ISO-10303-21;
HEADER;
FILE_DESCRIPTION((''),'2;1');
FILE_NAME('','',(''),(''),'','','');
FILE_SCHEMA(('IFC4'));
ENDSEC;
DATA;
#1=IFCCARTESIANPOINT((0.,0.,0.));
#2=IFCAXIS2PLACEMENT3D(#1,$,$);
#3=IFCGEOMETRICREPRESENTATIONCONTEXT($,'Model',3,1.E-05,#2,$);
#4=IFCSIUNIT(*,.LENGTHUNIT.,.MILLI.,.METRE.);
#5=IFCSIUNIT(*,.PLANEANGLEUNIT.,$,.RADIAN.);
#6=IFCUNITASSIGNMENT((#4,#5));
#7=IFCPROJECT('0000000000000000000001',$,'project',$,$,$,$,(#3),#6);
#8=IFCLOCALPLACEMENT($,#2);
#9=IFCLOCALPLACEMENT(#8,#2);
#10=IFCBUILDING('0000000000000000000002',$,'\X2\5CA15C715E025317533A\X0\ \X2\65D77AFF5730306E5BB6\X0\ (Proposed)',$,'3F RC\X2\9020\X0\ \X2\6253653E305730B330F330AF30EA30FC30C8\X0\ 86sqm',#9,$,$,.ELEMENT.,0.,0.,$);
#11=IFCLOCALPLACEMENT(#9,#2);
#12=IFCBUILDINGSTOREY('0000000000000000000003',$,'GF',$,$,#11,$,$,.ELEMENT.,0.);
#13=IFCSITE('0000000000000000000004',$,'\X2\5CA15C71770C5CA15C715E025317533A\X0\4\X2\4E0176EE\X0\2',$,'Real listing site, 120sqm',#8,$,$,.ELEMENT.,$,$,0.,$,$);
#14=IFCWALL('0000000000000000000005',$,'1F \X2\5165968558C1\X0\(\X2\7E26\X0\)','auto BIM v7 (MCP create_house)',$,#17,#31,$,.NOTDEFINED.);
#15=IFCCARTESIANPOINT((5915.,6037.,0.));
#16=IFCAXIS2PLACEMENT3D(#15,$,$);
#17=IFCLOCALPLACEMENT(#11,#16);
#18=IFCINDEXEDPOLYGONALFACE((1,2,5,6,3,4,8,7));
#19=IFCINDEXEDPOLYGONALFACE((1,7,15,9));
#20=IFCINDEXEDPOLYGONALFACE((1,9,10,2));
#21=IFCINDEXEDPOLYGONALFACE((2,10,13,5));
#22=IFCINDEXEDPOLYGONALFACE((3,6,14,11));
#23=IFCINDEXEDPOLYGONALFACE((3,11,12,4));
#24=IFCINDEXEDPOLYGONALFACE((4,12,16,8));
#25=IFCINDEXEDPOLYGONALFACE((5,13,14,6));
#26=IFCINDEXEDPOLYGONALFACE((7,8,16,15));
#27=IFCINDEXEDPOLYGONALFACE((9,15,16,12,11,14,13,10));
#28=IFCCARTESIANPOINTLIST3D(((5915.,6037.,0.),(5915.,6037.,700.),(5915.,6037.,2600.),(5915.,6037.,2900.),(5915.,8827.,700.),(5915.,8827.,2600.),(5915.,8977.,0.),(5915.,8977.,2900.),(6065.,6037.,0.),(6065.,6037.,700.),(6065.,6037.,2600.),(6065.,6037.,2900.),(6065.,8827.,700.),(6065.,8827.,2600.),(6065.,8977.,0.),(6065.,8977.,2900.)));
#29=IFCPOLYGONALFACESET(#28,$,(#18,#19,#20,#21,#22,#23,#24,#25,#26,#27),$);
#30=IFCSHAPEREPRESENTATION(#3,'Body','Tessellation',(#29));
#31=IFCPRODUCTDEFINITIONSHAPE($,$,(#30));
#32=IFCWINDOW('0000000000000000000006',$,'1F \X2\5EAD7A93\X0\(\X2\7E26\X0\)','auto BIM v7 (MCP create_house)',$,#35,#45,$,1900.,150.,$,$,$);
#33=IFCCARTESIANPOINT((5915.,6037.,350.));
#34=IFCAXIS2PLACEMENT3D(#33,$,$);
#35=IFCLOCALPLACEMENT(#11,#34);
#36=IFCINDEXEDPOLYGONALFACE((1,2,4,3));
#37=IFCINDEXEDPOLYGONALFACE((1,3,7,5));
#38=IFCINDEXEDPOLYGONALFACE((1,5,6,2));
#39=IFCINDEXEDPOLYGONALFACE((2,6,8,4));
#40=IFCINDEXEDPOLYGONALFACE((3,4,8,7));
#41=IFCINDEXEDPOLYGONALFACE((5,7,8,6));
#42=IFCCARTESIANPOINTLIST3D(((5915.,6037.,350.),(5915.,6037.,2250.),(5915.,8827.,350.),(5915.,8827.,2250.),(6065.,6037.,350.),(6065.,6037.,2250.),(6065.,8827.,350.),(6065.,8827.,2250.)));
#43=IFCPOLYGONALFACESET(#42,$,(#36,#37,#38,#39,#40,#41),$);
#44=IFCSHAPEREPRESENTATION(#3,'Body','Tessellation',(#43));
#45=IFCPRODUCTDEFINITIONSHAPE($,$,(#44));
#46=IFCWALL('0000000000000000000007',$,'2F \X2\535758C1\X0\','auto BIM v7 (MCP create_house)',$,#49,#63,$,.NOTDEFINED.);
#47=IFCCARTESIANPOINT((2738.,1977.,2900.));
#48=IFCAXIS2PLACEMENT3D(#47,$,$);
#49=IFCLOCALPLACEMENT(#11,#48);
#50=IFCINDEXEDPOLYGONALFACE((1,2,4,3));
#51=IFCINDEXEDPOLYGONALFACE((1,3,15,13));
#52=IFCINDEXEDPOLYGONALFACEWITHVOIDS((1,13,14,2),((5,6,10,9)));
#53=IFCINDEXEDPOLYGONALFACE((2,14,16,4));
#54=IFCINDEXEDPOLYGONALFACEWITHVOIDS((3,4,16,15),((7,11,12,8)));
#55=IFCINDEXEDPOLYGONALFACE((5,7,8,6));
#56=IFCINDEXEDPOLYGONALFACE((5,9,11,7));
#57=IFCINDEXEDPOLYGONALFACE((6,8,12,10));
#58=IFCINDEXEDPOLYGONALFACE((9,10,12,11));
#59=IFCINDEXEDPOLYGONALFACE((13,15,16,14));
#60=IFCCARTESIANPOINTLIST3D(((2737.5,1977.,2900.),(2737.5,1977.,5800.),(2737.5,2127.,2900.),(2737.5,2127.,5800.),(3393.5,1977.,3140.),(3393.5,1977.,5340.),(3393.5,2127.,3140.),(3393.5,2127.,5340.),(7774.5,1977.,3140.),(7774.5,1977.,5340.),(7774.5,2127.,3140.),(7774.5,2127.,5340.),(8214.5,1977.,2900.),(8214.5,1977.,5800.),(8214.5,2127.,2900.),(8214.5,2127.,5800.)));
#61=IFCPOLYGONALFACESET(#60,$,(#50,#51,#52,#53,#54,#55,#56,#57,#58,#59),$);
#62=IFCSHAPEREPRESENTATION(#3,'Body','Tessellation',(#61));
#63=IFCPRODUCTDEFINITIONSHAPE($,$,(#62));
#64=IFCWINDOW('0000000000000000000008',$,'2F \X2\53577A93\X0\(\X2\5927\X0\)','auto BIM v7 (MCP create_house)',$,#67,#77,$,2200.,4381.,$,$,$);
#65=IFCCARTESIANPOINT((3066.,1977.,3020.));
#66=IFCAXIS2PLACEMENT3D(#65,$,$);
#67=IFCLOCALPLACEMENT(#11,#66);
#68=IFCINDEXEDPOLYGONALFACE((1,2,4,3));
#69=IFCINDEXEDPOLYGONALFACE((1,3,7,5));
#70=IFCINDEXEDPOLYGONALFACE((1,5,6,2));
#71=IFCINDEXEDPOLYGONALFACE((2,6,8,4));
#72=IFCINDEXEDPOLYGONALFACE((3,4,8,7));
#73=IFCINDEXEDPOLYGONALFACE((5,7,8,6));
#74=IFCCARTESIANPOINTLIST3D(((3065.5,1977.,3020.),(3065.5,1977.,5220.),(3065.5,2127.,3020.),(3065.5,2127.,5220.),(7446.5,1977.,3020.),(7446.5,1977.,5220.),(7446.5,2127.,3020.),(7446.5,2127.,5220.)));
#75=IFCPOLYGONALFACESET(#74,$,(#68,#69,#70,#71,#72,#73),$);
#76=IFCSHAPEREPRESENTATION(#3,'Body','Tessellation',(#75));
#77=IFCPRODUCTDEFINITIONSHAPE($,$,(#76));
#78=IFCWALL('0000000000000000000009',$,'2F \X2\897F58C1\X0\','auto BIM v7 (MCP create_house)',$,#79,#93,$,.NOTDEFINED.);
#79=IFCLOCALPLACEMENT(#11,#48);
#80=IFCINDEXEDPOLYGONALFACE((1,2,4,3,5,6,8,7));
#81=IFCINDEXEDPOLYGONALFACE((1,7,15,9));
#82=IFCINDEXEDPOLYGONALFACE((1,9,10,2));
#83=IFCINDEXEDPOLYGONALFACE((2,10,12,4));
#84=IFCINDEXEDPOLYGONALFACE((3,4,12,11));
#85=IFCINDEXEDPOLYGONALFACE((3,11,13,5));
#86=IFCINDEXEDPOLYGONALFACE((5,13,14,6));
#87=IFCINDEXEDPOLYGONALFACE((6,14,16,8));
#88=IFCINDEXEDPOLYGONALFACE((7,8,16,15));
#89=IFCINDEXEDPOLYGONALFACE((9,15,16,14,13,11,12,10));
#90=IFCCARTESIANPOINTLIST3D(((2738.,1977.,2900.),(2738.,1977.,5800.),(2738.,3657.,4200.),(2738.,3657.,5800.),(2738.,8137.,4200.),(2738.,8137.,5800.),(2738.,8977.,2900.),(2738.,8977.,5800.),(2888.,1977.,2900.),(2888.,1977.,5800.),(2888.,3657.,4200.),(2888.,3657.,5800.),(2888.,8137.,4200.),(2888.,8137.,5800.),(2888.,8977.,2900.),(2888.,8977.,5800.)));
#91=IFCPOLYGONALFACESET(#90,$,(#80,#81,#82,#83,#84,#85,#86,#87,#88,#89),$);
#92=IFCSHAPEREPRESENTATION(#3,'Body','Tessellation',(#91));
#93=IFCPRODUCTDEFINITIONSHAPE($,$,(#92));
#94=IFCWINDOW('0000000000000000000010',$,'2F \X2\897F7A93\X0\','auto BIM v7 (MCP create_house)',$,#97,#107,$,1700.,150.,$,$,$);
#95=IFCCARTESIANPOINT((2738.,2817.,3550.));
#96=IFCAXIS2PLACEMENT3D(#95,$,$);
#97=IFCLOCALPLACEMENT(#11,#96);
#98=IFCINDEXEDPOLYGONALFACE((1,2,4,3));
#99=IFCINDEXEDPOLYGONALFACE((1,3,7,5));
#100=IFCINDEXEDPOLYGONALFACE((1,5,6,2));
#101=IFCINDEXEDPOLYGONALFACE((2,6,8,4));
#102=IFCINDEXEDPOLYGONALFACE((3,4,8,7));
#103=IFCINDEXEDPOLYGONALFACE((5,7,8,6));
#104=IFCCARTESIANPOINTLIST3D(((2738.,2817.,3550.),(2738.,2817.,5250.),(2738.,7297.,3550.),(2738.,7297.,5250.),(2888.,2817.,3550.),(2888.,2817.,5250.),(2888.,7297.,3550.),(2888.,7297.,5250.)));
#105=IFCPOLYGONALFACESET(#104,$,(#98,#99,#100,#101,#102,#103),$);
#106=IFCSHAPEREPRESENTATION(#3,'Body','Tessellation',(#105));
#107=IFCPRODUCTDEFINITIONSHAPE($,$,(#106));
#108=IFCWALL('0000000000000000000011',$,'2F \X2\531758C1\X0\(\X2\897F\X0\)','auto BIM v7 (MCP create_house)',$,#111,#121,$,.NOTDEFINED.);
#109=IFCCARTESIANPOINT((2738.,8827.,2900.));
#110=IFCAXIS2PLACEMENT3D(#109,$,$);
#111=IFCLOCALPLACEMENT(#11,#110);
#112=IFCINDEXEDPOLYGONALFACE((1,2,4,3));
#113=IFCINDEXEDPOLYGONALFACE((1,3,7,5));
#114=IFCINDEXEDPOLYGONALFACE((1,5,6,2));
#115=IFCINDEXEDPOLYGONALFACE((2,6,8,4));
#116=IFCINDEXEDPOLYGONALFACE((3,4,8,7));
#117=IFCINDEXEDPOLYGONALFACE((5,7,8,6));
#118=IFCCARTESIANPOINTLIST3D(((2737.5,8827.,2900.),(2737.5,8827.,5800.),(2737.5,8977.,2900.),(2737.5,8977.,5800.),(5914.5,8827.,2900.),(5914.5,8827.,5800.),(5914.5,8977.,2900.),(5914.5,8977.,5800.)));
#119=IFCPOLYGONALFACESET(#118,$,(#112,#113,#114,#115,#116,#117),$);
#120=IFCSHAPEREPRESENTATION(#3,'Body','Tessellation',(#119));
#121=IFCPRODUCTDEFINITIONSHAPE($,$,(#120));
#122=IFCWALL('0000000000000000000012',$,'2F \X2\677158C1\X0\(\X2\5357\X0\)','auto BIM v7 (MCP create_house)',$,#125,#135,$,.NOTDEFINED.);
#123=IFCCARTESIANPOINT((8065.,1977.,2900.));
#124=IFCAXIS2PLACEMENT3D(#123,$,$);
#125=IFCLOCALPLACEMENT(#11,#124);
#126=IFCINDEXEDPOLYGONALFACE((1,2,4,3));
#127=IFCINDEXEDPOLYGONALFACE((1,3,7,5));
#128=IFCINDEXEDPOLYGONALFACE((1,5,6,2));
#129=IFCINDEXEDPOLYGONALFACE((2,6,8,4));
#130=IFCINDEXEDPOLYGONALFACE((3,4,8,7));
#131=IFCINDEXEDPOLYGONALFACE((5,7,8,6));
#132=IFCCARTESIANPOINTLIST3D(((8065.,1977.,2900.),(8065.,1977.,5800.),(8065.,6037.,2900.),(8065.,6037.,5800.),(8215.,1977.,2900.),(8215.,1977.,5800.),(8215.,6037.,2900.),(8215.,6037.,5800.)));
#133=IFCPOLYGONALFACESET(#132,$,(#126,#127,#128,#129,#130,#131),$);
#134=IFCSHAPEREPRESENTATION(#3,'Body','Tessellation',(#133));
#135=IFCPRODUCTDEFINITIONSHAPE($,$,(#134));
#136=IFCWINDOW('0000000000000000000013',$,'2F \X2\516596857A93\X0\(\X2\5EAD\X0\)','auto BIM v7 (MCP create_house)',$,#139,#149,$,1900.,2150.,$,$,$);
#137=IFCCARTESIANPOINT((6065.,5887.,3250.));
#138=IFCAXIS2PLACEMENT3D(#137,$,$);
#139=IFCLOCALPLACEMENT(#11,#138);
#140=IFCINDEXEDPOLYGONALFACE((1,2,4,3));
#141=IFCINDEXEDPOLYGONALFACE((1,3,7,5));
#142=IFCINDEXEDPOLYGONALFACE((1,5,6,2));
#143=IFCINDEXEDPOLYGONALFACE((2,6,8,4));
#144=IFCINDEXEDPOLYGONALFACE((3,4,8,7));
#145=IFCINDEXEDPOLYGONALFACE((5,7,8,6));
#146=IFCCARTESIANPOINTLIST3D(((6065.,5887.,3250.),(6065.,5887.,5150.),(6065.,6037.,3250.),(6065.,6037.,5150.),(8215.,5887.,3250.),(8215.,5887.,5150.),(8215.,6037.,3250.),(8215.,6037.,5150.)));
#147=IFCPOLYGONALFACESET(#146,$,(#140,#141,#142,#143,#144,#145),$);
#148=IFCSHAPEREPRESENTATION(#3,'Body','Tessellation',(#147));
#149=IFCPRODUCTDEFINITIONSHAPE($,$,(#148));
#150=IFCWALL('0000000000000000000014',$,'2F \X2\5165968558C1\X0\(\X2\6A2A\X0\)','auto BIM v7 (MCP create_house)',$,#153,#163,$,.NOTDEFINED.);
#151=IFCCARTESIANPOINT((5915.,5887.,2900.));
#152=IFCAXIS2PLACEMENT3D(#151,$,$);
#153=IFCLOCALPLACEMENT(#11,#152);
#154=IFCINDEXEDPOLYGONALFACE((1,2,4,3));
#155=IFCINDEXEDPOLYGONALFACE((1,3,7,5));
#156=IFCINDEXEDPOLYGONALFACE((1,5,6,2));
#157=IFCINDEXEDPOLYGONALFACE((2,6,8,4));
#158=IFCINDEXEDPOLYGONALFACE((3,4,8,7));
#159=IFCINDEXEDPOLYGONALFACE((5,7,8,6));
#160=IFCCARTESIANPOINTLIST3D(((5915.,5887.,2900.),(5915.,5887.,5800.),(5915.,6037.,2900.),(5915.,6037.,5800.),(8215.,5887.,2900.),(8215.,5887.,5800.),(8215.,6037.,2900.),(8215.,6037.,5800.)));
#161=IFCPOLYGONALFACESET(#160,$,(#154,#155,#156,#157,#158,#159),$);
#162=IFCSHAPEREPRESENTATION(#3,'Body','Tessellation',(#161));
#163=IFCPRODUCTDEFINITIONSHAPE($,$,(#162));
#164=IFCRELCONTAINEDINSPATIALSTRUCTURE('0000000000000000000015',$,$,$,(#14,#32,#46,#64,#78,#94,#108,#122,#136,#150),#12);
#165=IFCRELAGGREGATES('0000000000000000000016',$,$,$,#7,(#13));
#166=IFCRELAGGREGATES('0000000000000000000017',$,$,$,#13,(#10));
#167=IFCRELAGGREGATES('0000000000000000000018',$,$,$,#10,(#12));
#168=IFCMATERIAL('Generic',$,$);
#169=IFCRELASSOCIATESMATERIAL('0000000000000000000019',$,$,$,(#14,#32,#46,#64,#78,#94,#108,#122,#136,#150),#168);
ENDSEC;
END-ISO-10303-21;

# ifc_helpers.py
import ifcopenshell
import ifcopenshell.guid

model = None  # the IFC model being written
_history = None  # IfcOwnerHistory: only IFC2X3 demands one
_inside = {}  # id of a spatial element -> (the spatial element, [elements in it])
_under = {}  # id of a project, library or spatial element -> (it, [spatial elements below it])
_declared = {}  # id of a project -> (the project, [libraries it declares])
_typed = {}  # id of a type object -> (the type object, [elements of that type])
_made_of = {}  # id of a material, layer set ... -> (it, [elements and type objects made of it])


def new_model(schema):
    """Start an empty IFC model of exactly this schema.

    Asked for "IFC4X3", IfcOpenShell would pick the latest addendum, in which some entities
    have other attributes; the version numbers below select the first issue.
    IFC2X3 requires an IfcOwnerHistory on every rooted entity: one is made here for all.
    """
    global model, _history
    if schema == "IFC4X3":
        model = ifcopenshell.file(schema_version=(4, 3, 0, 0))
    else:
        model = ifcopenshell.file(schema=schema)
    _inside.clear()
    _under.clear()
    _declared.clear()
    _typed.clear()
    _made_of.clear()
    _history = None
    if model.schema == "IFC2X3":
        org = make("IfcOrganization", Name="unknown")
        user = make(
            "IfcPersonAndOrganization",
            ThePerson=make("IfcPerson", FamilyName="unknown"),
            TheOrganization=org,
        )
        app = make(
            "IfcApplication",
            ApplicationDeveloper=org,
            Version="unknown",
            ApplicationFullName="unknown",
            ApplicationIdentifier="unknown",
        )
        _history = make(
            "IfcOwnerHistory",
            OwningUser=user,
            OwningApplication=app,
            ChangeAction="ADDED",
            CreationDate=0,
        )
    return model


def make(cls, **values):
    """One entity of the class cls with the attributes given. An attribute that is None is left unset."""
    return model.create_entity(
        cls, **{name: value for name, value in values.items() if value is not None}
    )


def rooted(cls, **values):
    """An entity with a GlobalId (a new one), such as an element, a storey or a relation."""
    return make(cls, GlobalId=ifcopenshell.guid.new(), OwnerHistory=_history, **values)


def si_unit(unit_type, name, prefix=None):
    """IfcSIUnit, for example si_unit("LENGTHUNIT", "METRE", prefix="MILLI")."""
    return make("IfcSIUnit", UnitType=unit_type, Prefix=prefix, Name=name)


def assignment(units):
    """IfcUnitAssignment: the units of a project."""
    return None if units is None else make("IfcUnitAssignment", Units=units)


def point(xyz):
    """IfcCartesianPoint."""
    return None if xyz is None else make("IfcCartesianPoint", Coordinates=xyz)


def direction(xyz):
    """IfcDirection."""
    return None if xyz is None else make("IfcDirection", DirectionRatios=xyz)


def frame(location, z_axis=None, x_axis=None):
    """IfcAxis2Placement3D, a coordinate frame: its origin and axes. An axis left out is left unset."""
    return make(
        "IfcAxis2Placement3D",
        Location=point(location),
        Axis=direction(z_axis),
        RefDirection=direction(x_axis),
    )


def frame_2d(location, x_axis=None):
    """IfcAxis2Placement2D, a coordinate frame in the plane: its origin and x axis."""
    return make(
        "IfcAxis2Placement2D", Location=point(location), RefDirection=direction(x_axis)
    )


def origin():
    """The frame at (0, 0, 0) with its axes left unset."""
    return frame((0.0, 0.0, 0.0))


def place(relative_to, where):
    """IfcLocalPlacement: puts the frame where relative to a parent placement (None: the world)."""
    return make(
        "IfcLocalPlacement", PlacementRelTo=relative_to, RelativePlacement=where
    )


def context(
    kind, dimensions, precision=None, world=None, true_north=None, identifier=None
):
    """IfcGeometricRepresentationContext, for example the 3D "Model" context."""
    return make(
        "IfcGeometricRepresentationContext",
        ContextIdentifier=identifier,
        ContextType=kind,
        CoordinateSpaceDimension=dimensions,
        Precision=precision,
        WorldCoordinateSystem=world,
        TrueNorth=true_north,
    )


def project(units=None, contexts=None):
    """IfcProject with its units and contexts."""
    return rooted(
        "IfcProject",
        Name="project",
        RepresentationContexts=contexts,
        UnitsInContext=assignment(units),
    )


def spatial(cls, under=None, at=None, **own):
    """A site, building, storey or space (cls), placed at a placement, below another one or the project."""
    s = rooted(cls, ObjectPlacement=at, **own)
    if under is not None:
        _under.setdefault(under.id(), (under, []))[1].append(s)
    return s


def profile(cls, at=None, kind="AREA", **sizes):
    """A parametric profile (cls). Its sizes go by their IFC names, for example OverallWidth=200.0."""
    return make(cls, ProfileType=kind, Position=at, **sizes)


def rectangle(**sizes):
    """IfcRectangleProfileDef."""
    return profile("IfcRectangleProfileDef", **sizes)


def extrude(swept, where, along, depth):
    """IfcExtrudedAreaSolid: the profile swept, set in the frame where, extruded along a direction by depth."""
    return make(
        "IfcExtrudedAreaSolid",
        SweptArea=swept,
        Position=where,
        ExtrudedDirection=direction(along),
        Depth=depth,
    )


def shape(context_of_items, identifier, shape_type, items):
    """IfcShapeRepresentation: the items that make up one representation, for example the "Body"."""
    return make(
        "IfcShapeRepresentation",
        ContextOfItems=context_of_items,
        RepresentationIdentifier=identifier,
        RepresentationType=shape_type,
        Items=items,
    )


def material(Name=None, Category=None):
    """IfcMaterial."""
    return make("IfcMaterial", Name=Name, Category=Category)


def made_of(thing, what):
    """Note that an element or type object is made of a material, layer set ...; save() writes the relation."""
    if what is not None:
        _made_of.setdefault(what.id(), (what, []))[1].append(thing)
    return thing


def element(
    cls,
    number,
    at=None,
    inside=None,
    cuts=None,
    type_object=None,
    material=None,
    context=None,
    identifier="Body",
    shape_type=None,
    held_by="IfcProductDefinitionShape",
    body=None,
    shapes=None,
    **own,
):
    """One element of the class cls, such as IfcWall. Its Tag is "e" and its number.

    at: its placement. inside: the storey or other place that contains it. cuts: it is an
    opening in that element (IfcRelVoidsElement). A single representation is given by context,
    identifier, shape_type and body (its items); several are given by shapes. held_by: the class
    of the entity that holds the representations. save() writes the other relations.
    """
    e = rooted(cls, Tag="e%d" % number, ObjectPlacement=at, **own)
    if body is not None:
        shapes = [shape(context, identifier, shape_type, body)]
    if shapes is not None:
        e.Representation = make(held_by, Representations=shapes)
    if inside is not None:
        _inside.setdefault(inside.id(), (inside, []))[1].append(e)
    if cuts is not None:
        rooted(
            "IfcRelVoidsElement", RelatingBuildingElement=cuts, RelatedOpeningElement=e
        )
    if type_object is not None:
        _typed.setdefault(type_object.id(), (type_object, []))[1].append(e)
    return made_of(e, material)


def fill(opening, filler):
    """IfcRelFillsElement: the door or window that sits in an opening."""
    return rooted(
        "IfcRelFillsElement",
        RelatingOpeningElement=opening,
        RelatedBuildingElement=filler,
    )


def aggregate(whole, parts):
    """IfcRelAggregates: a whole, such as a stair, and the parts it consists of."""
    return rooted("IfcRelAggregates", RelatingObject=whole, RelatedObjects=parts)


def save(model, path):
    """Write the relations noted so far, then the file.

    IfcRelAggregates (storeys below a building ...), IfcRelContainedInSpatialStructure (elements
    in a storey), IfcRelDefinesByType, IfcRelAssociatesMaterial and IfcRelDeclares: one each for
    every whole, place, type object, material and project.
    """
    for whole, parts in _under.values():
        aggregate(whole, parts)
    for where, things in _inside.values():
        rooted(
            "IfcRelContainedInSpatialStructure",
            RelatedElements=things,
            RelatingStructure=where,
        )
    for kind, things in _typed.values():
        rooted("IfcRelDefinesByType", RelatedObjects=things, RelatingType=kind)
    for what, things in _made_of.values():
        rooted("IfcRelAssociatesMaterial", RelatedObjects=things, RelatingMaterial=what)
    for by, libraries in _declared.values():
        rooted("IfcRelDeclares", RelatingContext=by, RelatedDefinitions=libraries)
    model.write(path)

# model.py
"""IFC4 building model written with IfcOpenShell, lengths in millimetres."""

from ifc_helpers import new_model, si_unit, frame, frame_2d, origin, place, context, project, spatial, rectangle, extrude, material, element, fill, save


model = new_model("IFC4")

# Units and contexts
model_context = context("Model", 3, precision=1e-05, world=origin())
ifc_project = project(units=[si_unit("LENGTHUNIT", "METRE", prefix="MILLI"), si_unit("PLANEANGLEUNIT", "RADIAN")], contexts=[model_context])

# Site, building, storey
site_placement = place(None, origin())
site = spatial("IfcSite", under=ifc_project, at=site_placement, Name="岡山県岡山市北区4丁目2", ObjectType="Real listing site, 120sqm", CompositionType="ELEMENT", RefElevation=0.0)
building_placement = place(site_placement, origin())
building = spatial("IfcBuilding", under=site, at=building_placement, Name="岡山市北区 旗竿地の家 (Proposed)", ObjectType="3F RC造 打放しコンクリート 86sqm", CompositionType="ELEMENT", ElevationOfRefHeight=0.0, ElevationOfTerrain=0.0)
storey_placement = place(building_placement, origin())
storey = spatial("IfcBuildingStorey", under=building, at=storey_placement, Name="GF", CompositionType="ELEMENT", Elevation=0.0)

# Shared definitions
ifc_material = material(Name="Generic")

# Wall, opening, window
wall_1_placement = place(storey_placement, frame((5915.0, 6037.0, 0.0)))
wall_1 = element("IfcWall", 1, at=wall_1_placement, inside=storey, material=ifc_material, Name="1F 入隅壁(縦)", Description="auto BIM v7 (MCP create_house)", PredefinedType="NOTDEFINED", context=model_context, shape_type="SweptSolid", body=[
    extrude(rectangle(XDim=150.0, YDim=2940.0, at=frame_2d((75.0, 1470.0))), frame((5915.0, 6037.0, 0.0)), (0.0, 0.0, 1.0), 2900.0),
])
opening_1_placement = place(storey_placement, frame((5915.0, 6037.0, 350.0)))
opening_1 = element("IfcOpeningElement", 2, at=opening_1_placement, cuts=wall_1, PredefinedType="NOTDEFINED", context=model_context, shape_type="SweptSolid", body=[
    extrude(rectangle(XDim=150.0, YDim=2790.0, at=frame_2d((75.0, 1395.0))), frame((5915.0, 6037.0, 350.0)), (0.0, 0.0, 1.0), 1900.0),
])
window_1_placement = place(storey_placement, frame((5915.0, 6037.0, 350.0)))
window_1 = element("IfcWindow", 3, at=window_1_placement, inside=storey, material=ifc_material, Name="1F 庭窓(縦)", Description="auto BIM v7 (MCP create_house)", OverallHeight=1900.0, OverallWidth=150.0, context=model_context, shape_type="SweptSolid", body=[
    extrude(rectangle(XDim=150.0, YDim=2790.0, at=frame_2d((75.0, 1395.0))), frame((5915.0, 6037.0, 350.0)), (0.0, 0.0, 1.0), 1900.0),
])
fill(opening_1, window_1)

# Walls, openings, windows
wall_2_placement = place(storey_placement, frame((2738.0, 1977.0, 2900.0)))
wall_2 = element("IfcWall", 4, at=wall_2_placement, inside=storey, material=ifc_material, Name="2F 南壁", Description="auto BIM v7 (MCP create_house)", PredefinedType="NOTDEFINED", context=model_context, shape_type="SweptSolid", body=[
    extrude(rectangle(XDim=5477.0, YDim=150.0, at=frame_2d((2738.0, 75.0))), frame((2738.0, 1977.0, 2900.0)), (0.0, 0.0, 1.0), 2900.0),
])
opening_2_placement = place(storey_placement, frame((3066.0, 1977.0, 3020.0)))
opening_2 = element("IfcOpeningElement", 5, at=opening_2_placement, cuts=wall_2, PredefinedType="NOTDEFINED", context=model_context, shape_type="SweptSolid", body=[
    extrude(rectangle(XDim=4381.0, YDim=150.0, at=frame_2d((2190.0, 75.0))), frame((3066.0, 1977.0, 3020.0)), (0.0, 0.0, 1.0), 2200.0),
])
window_2_placement = place(storey_placement, frame((3066.0, 1977.0, 3020.0)))
window_2 = element("IfcWindow", 6, at=window_2_placement, inside=storey, material=ifc_material, Name="2F 南窓(大)", Description="auto BIM v7 (MCP create_house)", OverallHeight=2200.0, OverallWidth=4381.0, context=model_context, shape_type="SweptSolid", body=[
    extrude(rectangle(XDim=4381.0, YDim=150.0, at=frame_2d((2190.0, 75.0))), frame((3066.0, 1977.0, 3020.0)), (0.0, 0.0, 1.0), 2200.0),
])
fill(opening_2, window_2)
wall_3_placement = place(storey_placement, frame((2738.0, 1977.0, 2900.0)))
wall_3 = element("IfcWall", 7, at=wall_3_placement, inside=storey, material=ifc_material, Name="2F 西壁", Description="auto BIM v7 (MCP create_house)", PredefinedType="NOTDEFINED", context=model_context, shape_type="SweptSolid", body=[
    extrude(rectangle(XDim=150.0, YDim=7000.0, at=frame_2d((75.0, 3500.0))), frame((2738.0, 1977.0, 2900.0)), (0.0, 0.0, 1.0), 2900.0),
])
opening_3_placement = place(storey_placement, frame((2738.0, 2817.0, 3550.0)))
opening_3 = element("IfcOpeningElement", 8, at=opening_3_placement, cuts=wall_3, PredefinedType="NOTDEFINED", context=model_context, shape_type="SweptSolid", body=[
    extrude(rectangle(XDim=150.0, YDim=4480.0, at=frame_2d((75.0, 2240.0))), frame((2738.0, 2817.0, 3550.0)), (0.0, 0.0, 1.0), 1700.0),
])
window_3_placement = place(storey_placement, frame((2738.0, 2817.0, 3550.0)))
window_3 = element("IfcWindow", 9, at=window_3_placement, inside=storey, material=ifc_material, Name="2F 西窓", Description="auto BIM v7 (MCP create_house)", OverallHeight=1700.0, OverallWidth=150.0, context=model_context, shape_type="SweptSolid", body=[
    extrude(rectangle(XDim=150.0, YDim=4480.0, at=frame_2d((75.0, 2240.0))), frame((2738.0, 2817.0, 3550.0)), (0.0, 0.0, 1.0), 1700.0),
])
fill(opening_3, window_3)

# Wall
wall_4_placement = place(storey_placement, frame((2738.0, 8827.0, 2900.0)))
element("IfcWall", 10, at=wall_4_placement, inside=storey, material=ifc_material, Name="2F 北壁(西)", Description="auto BIM v7 (MCP create_house)", PredefinedType="NOTDEFINED", context=model_context, shape_type="SweptSolid", body=[
    extrude(rectangle(XDim=3177.0, YDim=150.0, at=frame_2d((1588.0, 75.0))), frame((2738.0, 8827.0, 2900.0)), (0.0, 0.0, 1.0), 2900.0),
])

# Wall, opening, window
wall_5_placement = place(storey_placement, frame((8065.0, 1977.0, 2900.0)))
wall_5 = element("IfcWall", 11, at=wall_5_placement, inside=storey, material=ifc_material, Name="2F 東壁(南)", Description="auto BIM v7 (MCP create_house)", PredefinedType="NOTDEFINED", context=model_context, shape_type="SweptSolid", body=[
    extrude(rectangle(XDim=150.0, YDim=4060.0, at=frame_2d((75.0, 2030.0))), frame((8065.0, 1977.0, 2900.0)), (0.0, 0.0, 1.0), 2900.0),
])
opening_4_placement = place(storey_placement, frame((6065.0, 5887.0, 3250.0)))
opening_4 = element("IfcOpeningElement", 12, at=opening_4_placement, cuts=wall_5, PredefinedType="NOTDEFINED", context=model_context, shape_type="SweptSolid", body=[
    extrude(rectangle(XDim=2150.0, YDim=150.0, at=frame_2d((1075.0, 75.0))), frame((6065.0, 5887.0, 3250.0)), (0.0, 0.0, 1.0), 1900.0),
])
window_4_placement = place(storey_placement, frame((6065.0, 5887.0, 3250.0)))
window_4 = element("IfcWindow", 13, at=window_4_placement, inside=storey, material=ifc_material, Name="2F 入隅窓(庭)", Description="auto BIM v7 (MCP create_house)", OverallHeight=1900.0, OverallWidth=2150.0, context=model_context, shape_type="SweptSolid", body=[
    extrude(rectangle(XDim=2150.0, YDim=150.0, at=frame_2d((1075.0, 75.0))), frame((6065.0, 5887.0, 3250.0)), (0.0, 0.0, 1.0), 1900.0),
])
fill(opening_4, window_4)

# Wall
wall_6_placement = place(storey_placement, frame((5915.0, 5887.0, 2900.0)))
element("IfcWall", 14, at=wall_6_placement, inside=storey, material=ifc_material, Name="2F 入隅壁(横)", Description="auto BIM v7 (MCP create_house)", PredefinedType="NOTDEFINED", context=model_context, shape_type="SweptSolid", body=[
    extrude(rectangle(XDim=2300.0, YDim=150.0, at=frame_2d((1150.0, 75.0))), frame((5915.0, 5887.0, 2900.0)), (0.0, 0.0, 1.0), 2900.0),
])

save(model, "model.ifc")
